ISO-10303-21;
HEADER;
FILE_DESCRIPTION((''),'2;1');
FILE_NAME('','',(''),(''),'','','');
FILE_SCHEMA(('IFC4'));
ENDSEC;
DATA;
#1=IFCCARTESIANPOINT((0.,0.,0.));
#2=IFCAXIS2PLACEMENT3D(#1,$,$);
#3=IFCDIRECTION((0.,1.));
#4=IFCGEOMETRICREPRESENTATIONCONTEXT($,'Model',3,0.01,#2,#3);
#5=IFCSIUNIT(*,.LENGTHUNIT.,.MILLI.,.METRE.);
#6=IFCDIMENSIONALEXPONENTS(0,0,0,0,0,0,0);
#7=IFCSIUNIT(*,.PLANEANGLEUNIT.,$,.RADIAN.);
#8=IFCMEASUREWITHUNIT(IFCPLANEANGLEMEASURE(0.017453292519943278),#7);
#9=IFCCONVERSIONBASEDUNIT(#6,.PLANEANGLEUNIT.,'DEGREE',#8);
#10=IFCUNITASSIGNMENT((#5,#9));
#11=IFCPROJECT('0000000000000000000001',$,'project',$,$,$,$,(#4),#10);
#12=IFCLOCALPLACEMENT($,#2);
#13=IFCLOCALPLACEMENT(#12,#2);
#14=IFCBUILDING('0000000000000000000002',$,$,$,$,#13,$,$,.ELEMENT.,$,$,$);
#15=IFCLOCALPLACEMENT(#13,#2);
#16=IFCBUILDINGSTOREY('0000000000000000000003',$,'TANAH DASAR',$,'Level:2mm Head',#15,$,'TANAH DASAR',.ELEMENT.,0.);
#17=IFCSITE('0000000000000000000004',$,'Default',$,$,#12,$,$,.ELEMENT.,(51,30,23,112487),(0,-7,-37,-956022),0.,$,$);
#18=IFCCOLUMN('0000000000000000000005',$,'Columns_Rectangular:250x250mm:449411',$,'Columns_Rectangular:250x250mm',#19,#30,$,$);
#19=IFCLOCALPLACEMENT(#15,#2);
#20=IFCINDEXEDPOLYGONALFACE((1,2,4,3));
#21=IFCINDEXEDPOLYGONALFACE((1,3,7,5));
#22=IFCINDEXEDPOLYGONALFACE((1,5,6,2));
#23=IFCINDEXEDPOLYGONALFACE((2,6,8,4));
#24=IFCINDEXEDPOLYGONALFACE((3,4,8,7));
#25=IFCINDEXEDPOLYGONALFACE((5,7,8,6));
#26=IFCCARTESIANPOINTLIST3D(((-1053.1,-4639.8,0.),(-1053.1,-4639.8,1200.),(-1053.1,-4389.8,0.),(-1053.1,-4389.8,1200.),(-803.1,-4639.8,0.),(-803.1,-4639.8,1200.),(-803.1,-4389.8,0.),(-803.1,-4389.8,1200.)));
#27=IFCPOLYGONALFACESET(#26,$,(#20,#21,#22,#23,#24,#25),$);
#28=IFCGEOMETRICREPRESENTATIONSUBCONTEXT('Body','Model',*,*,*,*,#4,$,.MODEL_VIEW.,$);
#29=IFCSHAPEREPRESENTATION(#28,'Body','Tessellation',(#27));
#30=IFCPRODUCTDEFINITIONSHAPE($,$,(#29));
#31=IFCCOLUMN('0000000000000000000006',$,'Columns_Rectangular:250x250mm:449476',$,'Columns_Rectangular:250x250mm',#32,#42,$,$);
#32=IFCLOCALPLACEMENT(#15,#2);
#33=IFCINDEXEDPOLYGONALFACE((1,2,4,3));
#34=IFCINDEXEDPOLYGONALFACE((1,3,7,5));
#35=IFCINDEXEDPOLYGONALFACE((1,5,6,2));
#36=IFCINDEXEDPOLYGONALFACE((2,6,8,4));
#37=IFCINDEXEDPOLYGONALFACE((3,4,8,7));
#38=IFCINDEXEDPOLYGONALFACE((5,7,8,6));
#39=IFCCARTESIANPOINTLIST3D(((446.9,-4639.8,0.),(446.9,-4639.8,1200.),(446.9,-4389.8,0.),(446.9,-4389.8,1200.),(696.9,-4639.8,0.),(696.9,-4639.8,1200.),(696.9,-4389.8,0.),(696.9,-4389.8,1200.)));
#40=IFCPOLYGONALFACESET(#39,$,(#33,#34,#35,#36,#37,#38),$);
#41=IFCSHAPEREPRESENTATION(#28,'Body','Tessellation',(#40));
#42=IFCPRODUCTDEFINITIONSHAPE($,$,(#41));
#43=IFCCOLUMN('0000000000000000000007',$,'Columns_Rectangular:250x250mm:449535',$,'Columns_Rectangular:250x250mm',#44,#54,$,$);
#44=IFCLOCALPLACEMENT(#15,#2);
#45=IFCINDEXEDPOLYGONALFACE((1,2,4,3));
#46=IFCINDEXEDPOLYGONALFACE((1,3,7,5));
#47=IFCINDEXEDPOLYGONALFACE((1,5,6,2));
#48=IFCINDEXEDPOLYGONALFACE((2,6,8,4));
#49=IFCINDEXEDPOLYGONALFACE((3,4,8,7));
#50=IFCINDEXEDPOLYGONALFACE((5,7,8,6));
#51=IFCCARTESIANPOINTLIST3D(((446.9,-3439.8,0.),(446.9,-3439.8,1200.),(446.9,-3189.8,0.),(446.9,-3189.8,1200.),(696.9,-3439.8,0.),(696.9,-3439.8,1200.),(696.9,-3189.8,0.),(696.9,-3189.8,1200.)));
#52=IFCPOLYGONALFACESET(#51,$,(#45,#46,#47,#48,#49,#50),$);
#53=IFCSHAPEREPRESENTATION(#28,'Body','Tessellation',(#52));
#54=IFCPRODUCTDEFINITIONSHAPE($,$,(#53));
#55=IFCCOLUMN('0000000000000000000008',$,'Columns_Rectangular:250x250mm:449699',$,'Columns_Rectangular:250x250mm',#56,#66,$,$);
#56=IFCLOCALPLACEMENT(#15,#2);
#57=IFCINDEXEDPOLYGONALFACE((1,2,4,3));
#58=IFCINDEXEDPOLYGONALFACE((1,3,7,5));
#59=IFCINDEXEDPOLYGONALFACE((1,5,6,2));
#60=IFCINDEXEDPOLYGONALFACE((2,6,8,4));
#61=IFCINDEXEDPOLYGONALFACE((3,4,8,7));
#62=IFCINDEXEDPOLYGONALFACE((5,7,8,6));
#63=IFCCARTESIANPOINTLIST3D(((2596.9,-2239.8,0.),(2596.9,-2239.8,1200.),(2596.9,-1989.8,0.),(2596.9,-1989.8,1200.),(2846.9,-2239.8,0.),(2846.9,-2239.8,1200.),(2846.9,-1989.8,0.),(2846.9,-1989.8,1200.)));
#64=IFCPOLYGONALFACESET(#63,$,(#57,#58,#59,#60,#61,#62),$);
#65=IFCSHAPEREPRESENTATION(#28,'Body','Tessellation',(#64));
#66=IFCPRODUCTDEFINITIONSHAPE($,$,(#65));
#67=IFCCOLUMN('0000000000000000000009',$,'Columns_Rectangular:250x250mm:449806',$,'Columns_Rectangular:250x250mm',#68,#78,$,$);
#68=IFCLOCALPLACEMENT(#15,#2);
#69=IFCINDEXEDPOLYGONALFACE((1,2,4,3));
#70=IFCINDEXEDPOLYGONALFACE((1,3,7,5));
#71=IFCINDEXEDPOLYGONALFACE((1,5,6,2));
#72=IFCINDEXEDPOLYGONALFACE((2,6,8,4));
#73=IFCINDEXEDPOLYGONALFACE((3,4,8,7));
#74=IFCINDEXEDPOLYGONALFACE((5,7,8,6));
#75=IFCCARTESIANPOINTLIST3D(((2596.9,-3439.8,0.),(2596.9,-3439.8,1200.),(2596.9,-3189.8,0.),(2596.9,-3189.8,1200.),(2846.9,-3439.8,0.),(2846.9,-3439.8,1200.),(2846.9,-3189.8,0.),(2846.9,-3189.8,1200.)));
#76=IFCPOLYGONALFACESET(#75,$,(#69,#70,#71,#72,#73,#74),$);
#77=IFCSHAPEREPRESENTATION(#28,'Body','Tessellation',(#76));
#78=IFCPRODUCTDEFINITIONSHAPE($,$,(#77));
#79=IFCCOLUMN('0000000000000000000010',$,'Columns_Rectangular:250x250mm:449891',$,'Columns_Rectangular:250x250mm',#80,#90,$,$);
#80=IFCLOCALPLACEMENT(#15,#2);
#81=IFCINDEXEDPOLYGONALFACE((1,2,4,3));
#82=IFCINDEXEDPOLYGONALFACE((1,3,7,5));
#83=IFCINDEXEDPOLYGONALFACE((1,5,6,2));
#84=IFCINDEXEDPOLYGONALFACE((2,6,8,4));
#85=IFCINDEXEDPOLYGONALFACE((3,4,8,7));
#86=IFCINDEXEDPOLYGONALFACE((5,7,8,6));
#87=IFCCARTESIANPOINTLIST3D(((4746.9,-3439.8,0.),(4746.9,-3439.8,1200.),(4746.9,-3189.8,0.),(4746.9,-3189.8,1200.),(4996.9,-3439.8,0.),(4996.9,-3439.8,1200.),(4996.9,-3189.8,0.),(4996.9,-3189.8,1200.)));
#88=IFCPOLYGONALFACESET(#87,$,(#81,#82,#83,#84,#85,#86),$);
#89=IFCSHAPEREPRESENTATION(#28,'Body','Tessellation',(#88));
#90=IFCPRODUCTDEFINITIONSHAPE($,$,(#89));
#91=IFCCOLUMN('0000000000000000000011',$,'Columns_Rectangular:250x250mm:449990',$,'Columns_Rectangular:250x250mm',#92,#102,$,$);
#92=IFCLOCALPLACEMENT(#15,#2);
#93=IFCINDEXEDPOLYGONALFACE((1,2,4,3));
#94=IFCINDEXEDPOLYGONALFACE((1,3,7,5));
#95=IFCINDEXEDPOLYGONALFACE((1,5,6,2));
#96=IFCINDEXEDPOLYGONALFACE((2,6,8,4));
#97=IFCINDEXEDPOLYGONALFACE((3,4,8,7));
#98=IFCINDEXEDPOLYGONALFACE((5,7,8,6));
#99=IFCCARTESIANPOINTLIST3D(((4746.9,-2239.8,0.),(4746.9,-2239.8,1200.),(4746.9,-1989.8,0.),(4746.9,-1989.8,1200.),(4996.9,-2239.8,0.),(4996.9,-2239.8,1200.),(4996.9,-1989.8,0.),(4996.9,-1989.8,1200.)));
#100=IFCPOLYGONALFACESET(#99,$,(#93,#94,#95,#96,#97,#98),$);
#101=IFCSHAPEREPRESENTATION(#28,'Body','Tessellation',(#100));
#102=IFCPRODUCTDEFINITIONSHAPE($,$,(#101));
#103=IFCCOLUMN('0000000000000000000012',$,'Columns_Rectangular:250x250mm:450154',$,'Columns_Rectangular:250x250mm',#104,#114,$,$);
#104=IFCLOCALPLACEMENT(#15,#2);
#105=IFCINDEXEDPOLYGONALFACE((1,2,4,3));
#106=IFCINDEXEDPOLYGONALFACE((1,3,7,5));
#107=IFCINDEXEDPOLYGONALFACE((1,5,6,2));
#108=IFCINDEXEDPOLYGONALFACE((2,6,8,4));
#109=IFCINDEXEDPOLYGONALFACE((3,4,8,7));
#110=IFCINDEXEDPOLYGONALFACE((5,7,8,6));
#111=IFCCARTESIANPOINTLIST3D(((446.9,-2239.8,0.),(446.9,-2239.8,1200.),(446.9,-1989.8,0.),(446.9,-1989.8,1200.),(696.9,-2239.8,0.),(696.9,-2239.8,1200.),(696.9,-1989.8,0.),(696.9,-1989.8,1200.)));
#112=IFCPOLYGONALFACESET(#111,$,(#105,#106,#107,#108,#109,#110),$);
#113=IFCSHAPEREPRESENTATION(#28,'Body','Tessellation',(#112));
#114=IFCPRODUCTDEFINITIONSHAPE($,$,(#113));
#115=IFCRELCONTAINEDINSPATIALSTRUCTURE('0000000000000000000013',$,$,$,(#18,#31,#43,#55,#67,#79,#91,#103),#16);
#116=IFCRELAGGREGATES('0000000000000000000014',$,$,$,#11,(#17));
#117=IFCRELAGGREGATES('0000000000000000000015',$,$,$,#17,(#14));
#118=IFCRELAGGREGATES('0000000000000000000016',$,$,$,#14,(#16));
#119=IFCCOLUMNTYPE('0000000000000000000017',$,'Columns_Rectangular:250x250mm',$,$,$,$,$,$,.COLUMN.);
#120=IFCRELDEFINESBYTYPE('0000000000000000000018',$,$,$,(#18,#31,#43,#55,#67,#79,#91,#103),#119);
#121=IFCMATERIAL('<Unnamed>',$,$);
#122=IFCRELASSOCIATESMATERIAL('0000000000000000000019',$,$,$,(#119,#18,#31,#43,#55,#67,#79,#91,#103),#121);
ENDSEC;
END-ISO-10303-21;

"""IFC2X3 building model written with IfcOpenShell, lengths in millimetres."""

from ifc_helpers import new_model, entity, si_unit, converted_unit, direction, frame, origin, origin_2d_with_axis, place, context, subcontext, project, spatial, rectangle, extrude, source, transform, mapped, material, type_object, type_shapes, element, save


model = new_model("IFC2X3")

# Units and contexts
model_context = context("Model", 3, precision=0.01, world=origin(), true_north=direction((0.0, 1.0)))
body_context = subcontext(model_context, "Body", "Model", "MODEL_VIEW")
ifc_project = project(units=[si_unit("LENGTHUNIT", "METRE", prefix="MILLI"), converted_unit("PLANEANGLEUNIT", "DEGREE", entity("IfcPlaneAngleMeasure", 0.017453292519943278), si_unit("PLANEANGLEUNIT", "RADIAN"), dimensions=[0, 0, 0, 0, 0, 0, 0])], contexts=[model_context])

# Site, building, storey
site_placement = place(None, origin())
site = spatial("IfcSite", under=ifc_project, at=site_placement, Name="Default", CompositionType="ELEMENT", RefLatitude=(51, 30, 23, 112487), RefLongitude=(0, -7, -37, -956022), RefElevation=0.0)
building_placement = place(site_placement, origin())
building = spatial("IfcBuilding", under=site, at=building_placement, CompositionType="ELEMENT")
storey_placement = place(building_placement, origin())
storey = spatial("IfcBuildingStorey", under=building, at=storey_placement, Name="TANAH DASAR", ObjectType="Level:2mm Head", LongName="TANAH DASAR", CompositionType="ELEMENT", Elevation=0.0)

# Columns
ifc_material_1 = material(Name="<Unnamed>")
column_type = type_object("IfcColumnType", Name="Columns_Rectangular:250x250mm", PredefinedType="COLUMN", material=ifc_material_1)
shared_shape = source(origin(), body_context, "Body", "SweptSolid", [
    extrude(rectangle(XDim=250.0, YDim=250.0, at=origin_2d_with_axis()), frame((0.0, 0.0, 0.0), z_axis=(0.0, 0.0, 1.0), x_axis=(-1.0, 0.0, 0.0)), (0.0, 0.0, 1.0), 1200.0),
])
type_shapes(column_type, [shared_shape])
for number, where, name in (
    (1, (-928.1, -4514.8, 0.0), "Columns_Rectangular:250x250mm:449411"),
    (2, (571.9, -4514.8, 0.0), "Columns_Rectangular:250x250mm:449476"),
    (3, (571.9, -3314.8, 0.0), "Columns_Rectangular:250x250mm:449535"),
    (4, (2721.9, -2114.8, 0.0), "Columns_Rectangular:250x250mm:449699"),
    (5, (2721.9, -3314.8, 0.0), "Columns_Rectangular:250x250mm:449806"),
    (6, (4871.9, -3314.8, 0.0), "Columns_Rectangular:250x250mm:449891"),
    (7, (4871.9, -2114.8, 0.0), "Columns_Rectangular:250x250mm:449990"),
    (8, (571.9, -2114.8, 0.0), "Columns_Rectangular:250x250mm:450154"),
):
    element("IfcColumn", number, at=place(storey_placement, frame(where)), inside=storey, type_object=column_type, material=ifc_material_1, Name=name, ObjectType="Columns_Rectangular:250x250mm", context=body_context, shape_type="MappedRepresentation", body=[
        mapped(shared_shape, transform((0.0, 0.0, 0.0), scale=1.0)),
    ])

save(model, "model.ifc")
